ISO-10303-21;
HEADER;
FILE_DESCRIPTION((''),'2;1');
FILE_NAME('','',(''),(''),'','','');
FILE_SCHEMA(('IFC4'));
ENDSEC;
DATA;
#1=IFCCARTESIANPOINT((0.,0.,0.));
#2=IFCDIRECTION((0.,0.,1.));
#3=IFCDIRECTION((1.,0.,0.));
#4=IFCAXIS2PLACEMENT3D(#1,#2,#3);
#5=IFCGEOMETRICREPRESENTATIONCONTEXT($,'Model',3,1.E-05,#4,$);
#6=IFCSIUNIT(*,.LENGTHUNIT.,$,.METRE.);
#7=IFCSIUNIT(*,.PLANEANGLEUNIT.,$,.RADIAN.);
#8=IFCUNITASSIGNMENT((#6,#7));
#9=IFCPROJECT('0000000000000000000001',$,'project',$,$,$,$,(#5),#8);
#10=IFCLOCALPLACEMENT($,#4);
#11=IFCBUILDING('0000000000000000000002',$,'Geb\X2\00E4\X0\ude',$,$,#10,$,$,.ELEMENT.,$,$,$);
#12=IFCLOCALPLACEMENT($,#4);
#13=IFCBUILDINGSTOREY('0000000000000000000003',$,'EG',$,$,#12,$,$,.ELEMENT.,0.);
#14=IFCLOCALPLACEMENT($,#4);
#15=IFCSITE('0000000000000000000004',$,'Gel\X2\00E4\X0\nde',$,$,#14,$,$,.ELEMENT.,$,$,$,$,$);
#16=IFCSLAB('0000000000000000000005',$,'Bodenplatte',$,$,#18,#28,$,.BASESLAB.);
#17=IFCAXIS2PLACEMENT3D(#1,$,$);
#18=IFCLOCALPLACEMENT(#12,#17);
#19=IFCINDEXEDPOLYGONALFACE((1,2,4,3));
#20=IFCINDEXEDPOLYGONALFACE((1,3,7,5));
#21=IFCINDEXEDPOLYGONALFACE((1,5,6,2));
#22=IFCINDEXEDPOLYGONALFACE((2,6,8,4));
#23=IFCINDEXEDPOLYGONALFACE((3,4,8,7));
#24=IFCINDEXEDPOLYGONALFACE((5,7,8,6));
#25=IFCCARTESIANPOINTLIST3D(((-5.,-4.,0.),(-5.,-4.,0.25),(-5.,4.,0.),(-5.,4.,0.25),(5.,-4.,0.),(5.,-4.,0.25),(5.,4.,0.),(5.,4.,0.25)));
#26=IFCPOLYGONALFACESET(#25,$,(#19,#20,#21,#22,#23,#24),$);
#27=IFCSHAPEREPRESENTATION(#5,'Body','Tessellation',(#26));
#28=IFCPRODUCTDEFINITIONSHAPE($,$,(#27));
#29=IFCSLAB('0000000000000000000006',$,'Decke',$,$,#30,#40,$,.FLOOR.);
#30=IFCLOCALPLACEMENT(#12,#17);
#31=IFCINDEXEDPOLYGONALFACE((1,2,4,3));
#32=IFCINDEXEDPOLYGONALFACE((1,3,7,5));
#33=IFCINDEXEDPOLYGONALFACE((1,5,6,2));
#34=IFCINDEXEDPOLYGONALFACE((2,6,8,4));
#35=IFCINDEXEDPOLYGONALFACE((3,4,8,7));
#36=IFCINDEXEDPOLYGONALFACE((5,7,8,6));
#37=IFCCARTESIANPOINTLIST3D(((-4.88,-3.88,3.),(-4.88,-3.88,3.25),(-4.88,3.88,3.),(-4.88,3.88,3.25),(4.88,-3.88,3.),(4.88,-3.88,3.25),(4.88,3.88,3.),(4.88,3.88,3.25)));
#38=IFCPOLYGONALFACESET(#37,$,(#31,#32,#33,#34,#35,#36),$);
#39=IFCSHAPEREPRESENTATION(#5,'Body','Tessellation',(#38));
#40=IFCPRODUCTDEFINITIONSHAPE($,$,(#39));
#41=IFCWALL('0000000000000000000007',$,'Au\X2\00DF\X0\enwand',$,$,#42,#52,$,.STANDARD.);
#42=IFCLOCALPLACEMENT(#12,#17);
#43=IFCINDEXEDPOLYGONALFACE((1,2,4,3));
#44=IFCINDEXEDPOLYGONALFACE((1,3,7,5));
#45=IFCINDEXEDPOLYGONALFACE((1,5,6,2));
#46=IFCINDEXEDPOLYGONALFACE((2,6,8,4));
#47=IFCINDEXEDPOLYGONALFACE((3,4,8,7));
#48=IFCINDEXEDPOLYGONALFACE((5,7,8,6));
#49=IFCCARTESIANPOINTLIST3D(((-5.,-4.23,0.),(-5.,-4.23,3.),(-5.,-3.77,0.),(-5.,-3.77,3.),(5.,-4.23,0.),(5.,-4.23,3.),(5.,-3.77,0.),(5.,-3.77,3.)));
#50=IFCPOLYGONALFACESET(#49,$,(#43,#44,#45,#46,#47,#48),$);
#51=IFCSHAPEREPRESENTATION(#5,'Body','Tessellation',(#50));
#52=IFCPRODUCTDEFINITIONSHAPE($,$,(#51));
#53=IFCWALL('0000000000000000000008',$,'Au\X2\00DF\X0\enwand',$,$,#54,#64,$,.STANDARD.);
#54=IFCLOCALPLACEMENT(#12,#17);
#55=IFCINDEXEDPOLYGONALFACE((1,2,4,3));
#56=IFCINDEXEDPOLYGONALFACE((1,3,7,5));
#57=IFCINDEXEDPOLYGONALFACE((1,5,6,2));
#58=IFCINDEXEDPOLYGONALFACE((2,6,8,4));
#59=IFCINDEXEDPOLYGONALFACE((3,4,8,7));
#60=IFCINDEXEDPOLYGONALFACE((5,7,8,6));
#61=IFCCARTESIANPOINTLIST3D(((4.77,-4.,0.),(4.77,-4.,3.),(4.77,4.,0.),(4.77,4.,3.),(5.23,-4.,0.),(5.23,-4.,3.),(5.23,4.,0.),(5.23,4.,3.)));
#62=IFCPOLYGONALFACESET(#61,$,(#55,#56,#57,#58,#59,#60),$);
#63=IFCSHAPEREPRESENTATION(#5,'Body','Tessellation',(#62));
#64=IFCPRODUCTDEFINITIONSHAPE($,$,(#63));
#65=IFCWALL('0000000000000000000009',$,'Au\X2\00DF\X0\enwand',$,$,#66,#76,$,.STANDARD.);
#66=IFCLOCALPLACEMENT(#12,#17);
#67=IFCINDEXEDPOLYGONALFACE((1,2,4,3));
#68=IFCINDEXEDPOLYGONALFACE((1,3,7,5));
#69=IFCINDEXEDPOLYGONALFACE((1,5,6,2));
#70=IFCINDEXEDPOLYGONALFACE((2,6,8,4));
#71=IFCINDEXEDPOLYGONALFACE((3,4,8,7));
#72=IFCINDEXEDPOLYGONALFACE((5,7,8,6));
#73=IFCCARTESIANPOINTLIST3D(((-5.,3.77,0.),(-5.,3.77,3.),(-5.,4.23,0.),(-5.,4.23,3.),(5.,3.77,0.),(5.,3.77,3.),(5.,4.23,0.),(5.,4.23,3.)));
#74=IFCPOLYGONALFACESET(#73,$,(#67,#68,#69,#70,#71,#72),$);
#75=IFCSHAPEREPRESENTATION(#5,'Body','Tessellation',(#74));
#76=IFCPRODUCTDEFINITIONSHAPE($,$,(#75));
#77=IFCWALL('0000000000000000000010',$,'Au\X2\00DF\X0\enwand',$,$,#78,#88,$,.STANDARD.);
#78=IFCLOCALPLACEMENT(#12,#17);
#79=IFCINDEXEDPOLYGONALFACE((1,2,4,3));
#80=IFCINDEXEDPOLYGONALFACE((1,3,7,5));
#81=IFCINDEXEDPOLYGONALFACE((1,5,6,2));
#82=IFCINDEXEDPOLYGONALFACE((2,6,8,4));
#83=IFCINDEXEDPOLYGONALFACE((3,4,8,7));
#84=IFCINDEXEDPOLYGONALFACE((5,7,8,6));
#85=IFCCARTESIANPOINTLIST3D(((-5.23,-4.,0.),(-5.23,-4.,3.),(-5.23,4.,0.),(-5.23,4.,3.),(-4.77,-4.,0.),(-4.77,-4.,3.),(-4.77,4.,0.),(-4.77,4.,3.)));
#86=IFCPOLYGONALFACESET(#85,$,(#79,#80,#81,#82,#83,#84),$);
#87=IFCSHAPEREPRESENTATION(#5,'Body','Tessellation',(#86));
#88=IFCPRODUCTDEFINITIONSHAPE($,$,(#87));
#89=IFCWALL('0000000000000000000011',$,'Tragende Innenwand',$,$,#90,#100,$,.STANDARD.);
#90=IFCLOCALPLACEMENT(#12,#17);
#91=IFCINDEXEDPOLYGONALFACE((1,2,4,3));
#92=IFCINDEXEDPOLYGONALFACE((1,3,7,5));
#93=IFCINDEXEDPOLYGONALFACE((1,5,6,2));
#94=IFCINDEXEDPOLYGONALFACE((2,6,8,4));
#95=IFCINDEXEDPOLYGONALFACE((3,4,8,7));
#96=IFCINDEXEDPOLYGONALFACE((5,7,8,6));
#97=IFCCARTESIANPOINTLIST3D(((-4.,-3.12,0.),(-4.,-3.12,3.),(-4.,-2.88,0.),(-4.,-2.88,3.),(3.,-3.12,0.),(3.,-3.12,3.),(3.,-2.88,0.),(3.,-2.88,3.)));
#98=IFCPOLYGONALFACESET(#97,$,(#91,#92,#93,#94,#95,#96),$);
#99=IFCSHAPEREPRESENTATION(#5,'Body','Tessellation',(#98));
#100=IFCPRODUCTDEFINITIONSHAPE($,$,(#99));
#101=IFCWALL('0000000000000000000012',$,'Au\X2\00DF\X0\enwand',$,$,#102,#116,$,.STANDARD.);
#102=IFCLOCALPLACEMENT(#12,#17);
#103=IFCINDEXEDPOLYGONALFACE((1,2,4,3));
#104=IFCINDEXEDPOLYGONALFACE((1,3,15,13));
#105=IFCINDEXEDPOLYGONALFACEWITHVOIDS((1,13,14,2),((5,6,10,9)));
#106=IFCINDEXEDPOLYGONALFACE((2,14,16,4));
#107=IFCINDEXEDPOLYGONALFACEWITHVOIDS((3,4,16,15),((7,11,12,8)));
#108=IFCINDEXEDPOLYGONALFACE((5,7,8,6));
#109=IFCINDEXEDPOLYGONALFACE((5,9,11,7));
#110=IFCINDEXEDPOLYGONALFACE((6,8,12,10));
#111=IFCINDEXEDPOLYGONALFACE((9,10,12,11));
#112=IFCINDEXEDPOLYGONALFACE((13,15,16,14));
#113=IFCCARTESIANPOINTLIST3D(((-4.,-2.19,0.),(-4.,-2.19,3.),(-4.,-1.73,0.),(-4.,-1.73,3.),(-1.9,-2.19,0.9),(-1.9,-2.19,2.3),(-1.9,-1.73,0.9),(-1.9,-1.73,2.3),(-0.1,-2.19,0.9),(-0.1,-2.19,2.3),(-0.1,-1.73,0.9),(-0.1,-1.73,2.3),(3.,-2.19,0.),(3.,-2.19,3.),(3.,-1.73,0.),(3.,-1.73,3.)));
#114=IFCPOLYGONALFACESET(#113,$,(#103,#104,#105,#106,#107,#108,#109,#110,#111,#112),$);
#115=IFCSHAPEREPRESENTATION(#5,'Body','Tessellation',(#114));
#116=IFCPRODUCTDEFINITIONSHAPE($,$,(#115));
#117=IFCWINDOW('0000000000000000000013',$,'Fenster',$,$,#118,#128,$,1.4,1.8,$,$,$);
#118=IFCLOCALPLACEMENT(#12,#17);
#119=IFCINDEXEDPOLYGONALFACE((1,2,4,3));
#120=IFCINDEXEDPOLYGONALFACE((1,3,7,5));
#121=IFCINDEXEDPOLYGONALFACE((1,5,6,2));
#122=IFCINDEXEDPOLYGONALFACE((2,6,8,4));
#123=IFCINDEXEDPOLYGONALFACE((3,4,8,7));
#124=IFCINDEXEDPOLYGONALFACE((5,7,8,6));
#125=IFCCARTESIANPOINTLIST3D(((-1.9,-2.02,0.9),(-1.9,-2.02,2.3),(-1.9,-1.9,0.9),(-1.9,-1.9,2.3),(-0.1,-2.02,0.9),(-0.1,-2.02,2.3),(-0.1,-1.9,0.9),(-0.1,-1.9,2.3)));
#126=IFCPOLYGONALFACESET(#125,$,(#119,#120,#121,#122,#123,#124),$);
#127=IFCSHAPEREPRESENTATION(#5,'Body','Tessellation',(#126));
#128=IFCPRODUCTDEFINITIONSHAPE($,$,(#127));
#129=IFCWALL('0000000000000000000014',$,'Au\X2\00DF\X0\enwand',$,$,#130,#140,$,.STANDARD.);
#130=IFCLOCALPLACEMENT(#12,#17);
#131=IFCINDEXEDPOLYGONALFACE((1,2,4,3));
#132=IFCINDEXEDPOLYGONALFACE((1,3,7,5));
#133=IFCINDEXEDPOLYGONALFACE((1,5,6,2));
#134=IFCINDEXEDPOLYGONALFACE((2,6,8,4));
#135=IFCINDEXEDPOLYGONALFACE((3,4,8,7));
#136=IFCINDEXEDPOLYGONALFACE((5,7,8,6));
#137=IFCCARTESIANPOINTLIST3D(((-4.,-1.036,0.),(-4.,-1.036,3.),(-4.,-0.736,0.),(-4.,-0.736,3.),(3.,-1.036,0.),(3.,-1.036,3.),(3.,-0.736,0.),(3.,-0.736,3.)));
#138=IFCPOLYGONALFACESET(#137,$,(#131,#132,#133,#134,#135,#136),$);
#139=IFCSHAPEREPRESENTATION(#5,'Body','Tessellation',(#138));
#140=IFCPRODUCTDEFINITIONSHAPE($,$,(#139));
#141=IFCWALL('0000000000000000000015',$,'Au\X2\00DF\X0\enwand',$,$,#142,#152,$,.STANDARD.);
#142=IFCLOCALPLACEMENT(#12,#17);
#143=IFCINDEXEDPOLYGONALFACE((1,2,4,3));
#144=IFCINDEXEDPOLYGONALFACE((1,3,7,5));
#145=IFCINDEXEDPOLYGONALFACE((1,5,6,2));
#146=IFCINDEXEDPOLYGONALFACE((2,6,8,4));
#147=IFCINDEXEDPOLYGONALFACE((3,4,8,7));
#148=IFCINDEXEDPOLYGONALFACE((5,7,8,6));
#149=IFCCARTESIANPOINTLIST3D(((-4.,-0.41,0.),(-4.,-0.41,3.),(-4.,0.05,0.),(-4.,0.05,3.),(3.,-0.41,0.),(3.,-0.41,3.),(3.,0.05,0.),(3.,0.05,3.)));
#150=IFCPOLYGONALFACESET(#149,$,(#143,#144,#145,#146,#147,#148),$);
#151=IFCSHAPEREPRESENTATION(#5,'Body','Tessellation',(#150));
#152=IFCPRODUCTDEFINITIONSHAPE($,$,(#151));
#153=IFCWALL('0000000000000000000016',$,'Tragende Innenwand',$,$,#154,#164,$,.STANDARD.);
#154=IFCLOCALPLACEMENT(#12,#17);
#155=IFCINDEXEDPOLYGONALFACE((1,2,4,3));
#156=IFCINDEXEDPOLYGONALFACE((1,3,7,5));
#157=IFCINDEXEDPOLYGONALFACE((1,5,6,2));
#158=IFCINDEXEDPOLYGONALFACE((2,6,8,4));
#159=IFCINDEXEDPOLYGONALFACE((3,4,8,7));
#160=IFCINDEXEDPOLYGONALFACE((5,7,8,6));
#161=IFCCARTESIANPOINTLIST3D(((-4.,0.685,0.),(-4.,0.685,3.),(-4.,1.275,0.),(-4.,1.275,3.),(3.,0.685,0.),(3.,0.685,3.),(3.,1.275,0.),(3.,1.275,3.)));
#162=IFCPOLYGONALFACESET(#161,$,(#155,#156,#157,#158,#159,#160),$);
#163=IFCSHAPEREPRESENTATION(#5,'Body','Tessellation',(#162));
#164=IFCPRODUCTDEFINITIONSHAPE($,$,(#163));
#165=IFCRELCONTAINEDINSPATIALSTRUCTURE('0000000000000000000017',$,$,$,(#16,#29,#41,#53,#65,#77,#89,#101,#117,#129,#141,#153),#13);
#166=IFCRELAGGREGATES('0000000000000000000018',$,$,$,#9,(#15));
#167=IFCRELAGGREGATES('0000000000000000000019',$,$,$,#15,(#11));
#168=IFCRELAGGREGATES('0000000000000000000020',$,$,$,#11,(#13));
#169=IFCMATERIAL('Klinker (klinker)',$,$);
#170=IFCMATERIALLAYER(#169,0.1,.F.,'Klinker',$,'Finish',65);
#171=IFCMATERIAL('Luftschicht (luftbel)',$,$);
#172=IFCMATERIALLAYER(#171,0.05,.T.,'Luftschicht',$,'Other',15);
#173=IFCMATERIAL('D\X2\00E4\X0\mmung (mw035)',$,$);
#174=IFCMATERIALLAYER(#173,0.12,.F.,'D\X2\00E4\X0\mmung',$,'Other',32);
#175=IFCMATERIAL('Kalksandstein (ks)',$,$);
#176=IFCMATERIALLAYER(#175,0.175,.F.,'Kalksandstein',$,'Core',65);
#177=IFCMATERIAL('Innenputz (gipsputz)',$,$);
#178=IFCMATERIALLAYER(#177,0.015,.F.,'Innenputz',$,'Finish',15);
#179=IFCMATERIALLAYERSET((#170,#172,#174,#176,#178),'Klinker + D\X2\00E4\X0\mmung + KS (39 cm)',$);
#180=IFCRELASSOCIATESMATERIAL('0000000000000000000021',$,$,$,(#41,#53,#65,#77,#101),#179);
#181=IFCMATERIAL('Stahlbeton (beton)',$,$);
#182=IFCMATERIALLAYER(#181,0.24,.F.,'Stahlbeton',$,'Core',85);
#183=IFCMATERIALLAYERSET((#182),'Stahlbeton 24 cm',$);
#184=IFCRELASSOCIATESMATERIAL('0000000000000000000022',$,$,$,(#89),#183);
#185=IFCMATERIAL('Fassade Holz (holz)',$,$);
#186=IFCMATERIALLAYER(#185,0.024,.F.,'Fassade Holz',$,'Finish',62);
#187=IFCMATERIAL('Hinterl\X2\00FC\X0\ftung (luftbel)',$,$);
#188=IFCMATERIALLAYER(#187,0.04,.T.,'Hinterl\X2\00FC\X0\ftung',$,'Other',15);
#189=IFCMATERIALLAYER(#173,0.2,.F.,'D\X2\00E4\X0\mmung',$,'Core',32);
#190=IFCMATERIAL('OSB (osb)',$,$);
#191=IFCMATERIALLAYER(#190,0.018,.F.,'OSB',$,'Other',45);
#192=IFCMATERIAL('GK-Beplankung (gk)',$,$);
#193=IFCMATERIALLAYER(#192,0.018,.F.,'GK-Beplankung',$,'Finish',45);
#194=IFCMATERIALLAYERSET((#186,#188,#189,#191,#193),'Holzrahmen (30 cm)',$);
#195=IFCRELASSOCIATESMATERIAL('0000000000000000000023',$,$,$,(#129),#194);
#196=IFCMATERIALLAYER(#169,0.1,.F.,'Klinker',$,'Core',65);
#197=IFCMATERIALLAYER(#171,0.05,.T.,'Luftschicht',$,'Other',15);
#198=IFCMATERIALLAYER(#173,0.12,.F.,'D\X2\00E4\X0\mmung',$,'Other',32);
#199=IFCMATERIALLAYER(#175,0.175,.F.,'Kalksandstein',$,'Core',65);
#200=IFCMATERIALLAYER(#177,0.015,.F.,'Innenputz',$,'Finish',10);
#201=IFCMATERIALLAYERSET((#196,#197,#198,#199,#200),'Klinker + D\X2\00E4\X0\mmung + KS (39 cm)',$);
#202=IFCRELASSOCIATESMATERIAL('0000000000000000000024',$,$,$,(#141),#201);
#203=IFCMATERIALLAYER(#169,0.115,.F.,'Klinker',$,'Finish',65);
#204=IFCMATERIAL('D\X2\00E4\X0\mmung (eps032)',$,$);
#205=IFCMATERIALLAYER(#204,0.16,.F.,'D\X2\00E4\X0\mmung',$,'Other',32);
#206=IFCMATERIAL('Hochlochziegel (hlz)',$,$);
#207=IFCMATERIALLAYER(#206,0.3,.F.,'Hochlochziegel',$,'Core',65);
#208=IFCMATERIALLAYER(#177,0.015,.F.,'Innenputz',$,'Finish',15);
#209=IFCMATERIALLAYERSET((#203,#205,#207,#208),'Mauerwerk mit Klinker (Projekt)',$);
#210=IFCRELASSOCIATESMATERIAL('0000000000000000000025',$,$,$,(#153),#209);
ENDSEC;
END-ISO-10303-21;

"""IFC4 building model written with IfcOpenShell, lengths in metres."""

from ifc_helpers import new_model, si_unit, frame, origin_with_axes, origin_2d, place, context, project, spatial, polyline, rectangle, outline, extrude, material, layer, layer_set, layer_usage, element, fill, save


model = new_model("IFC4")

# Units and contexts
model_context = context("Model", 3, precision=1e-05, world=origin_with_axes())
ifc_project = project(units=[si_unit("LENGTHUNIT", "METRE"), si_unit("PLANEANGLEUNIT", "RADIAN")], contexts=[model_context])

# Site, building, storey
site_placement = place(None, origin_with_axes())
site = spatial("IfcSite", under=ifc_project, at=site_placement, Name="Gelände", CompositionType="ELEMENT")
building_placement = place(None, origin_with_axes())
building = spatial("IfcBuilding", under=site, at=building_placement, Name="Gebäude", CompositionType="ELEMENT")
storey_placement = place(None, origin_with_axes())
storey = spatial("IfcBuildingStorey", under=building, at=storey_placement, Name="EG", CompositionType="ELEMENT", Elevation=0.0)

# Slabs
slab_1_placement = place(None, origin_with_axes())
element("IfcSlab", 1, at=slab_1_placement, inside=storey, Name="Bodenplatte", PredefinedType="BASESLAB", context=model_context, shape_type="SweptSolid", body=[
    extrude(outline(polyline([(-5.0, -4.0), (5.0, -4.0), (5.0, 4.0), (-5.0, 4.0), (-5.0, -4.0)])), origin_with_axes(), (0.0, 0.0, 1.0), 0.25),
])
slab_2_placement = place(None, frame((0.0, 0.0, 3.0), z_axis=(0.0, 0.0, 1.0), x_axis=(1.0, 0.0, 0.0)))
element("IfcSlab", 2, at=slab_2_placement, inside=storey, Name="Decke", PredefinedType="FLOOR", context=model_context, shape_type="SweptSolid", body=[
    extrude(outline(polyline([(-4.88, -3.88), (4.88, -3.88), (4.88, 3.88), (-4.88, 3.88), (-4.88, -3.88)])), origin_with_axes(), (0.0, 0.0, 1.0), 0.25),
])

# Walls
ifc_material_1 = material(Name="Klinker (klinker)")
ifc_layer_1 = layer(ifc_material_1, 0.1, ventilated=False, Name="Klinker", Category="Finish", Priority=65)
ifc_material_2 = material(Name="Luftschicht (luftbel)")
ifc_layer_2 = layer(ifc_material_2, 0.05, ventilated=True, Name="Luftschicht", Category="Other", Priority=15)
ifc_material_3 = material(Name="Dämmung (mw035)")
ifc_layer_3 = layer(ifc_material_3, 0.12, ventilated=False, Name="Dämmung", Category="Other", Priority=32)
ifc_material_4 = material(Name="Kalksandstein (ks)")
ifc_layer_4 = layer(ifc_material_4, 0.175, ventilated=False, Name="Kalksandstein", Category="Core", Priority=65)
ifc_material_5 = material(Name="Innenputz (gipsputz)")
ifc_layer_5 = layer(ifc_material_5, 0.015, ventilated=False, Name="Innenputz", Category="Finish", Priority=15)
ifc_layer_set_1 = layer_set([ifc_layer_1, ifc_layer_2, ifc_layer_3, ifc_layer_4, ifc_layer_5], Name="Klinker + Dämmung + KS (39 cm)")
ifc_layer_usage_1 = layer_usage(ifc_layer_set_1, "AXIS2", "NEGATIVE", 0.23)
wall_1_placement = place(None, frame((0.0, -4.0, 0.0), z_axis=(0.0, 0.0, 1.0), x_axis=(1.0, 0.0, 0.0)))
element("IfcWall", 3, at=wall_1_placement, inside=storey, material=ifc_layer_usage_1, Name="Außenwand", PredefinedType="STANDARD", context=model_context, shape_type="SweptSolid", body=[
    extrude(rectangle(XDim=10.0, YDim=0.46, at=origin_2d()), origin_with_axes(), (0.0, 0.0, 1.0), 3.0),
])
ifc_layer_usage_2 = layer_usage(ifc_layer_set_1, "AXIS2", "NEGATIVE", 0.23)
wall_2_placement = place(None, frame((5.0, 0.0, 0.0), z_axis=(0.0, 0.0, 1.0), x_axis=(0.0, 1.0, 0.0)))
element("IfcWall", 4, at=wall_2_placement, inside=storey, material=ifc_layer_usage_2, Name="Außenwand", PredefinedType="STANDARD", context=model_context, shape_type="SweptSolid", body=[
    extrude(rectangle(XDim=8.0, YDim=0.46, at=origin_2d()), origin_with_axes(), (0.0, 0.0, 1.0), 3.0),
])
ifc_layer_usage_3 = layer_usage(ifc_layer_set_1, "AXIS2", "NEGATIVE", 0.23)
wall_3_placement = place(None, frame((0.0, 4.0, 0.0), z_axis=(0.0, 0.0, 1.0), x_axis=(-1.0, 0.0, 0.0)))
element("IfcWall", 5, at=wall_3_placement, inside=storey, material=ifc_layer_usage_3, Name="Außenwand", PredefinedType="STANDARD", context=model_context, shape_type="SweptSolid", body=[
    extrude(rectangle(XDim=10.0, YDim=0.46, at=origin_2d()), origin_with_axes(), (0.0, 0.0, 1.0), 3.0),
])
ifc_layer_usage_4 = layer_usage(ifc_layer_set_1, "AXIS2", "NEGATIVE", 0.23)
wall_4_placement = place(None, frame((-5.0, 0.0, 0.0), z_axis=(0.0, 0.0, 1.0), x_axis=(0.0, -1.0, 0.0)))
element("IfcWall", 6, at=wall_4_placement, inside=storey, material=ifc_layer_usage_4, Name="Außenwand", PredefinedType="STANDARD", context=model_context, shape_type="SweptSolid", body=[
    extrude(rectangle(XDim=8.0, YDim=0.46, at=origin_2d()), origin_with_axes(), (0.0, 0.0, 1.0), 3.0),
])
ifc_material_6 = material(Name="Stahlbeton (beton)")
ifc_layer_6 = layer(ifc_material_6, 0.24, ventilated=False, Name="Stahlbeton", Category="Core", Priority=85)
ifc_layer_set_2 = layer_set([ifc_layer_6], Name="Stahlbeton 24 cm")
ifc_layer_usage_5 = layer_usage(ifc_layer_set_2, "AXIS2", "NEGATIVE", 0.12)
wall_5_placement = place(None, frame((-0.5, -3.0, 0.0), z_axis=(0.0, 0.0, 1.0), x_axis=(1.0, 0.0, 0.0)))
element("IfcWall", 7, at=wall_5_placement, inside=storey, material=ifc_layer_usage_5, Name="Tragende Innenwand", PredefinedType="STANDARD", context=model_context, shape_type="SweptSolid", body=[
    extrude(rectangle(XDim=7.0, YDim=0.24, at=origin_2d()), origin_with_axes(), (0.0, 0.0, 1.0), 3.0),
])

# Wall, opening, window
ifc_layer_usage_6 = layer_usage(ifc_layer_set_1, "AXIS2", "NEGATIVE", 0.23)
wall_6_placement = place(None, frame((-0.5, -1.96, 0.0), z_axis=(0.0, 0.0, 1.0), x_axis=(1.0, 0.0, 0.0)))
wall_6 = element("IfcWall", 8, at=wall_6_placement, inside=storey, material=ifc_layer_usage_6, Name="Außenwand", PredefinedType="STANDARD", context=model_context, shape_type="SweptSolid", body=[
    extrude(rectangle(XDim=7.0, YDim=0.46, at=origin_2d()), origin_with_axes(), (0.0, 0.0, 1.0), 3.0),
])
opening_placement = place(wall_6_placement, frame((-0.5, 0.0, 0.9), z_axis=(0.0, 0.0, 1.0), x_axis=(1.0, 0.0, 0.0)))
opening = element("IfcOpeningElement", 9, at=opening_placement, cuts=wall_6, PredefinedType="OPENING", context=model_context, shape_type="SweptSolid", body=[
    extrude(rectangle(XDim=1.8, YDim=0.5, at=origin_2d()), origin_with_axes(), (0.0, 0.0, 1.0), 1.4),
])
window_placement = place(opening_placement, origin_with_axes())
window = element("IfcWindow", 10, at=window_placement, inside=storey, Name="Fenster", OverallHeight=1.4, OverallWidth=1.8, context=model_context, shape_type="SweptSolid", body=[
    extrude(rectangle(XDim=1.8, YDim=0.12, at=origin_2d()), origin_with_axes(), (0.0, 0.0, 1.0), 1.4),
])
fill(opening, window)

# Walls
ifc_material_7 = material(Name="Fassade Holz (holz)")
ifc_layer_7 = layer(ifc_material_7, 0.024, ventilated=False, Name="Fassade Holz", Category="Finish", Priority=62)
ifc_material_8 = material(Name="Hinterlüftung (luftbel)")
ifc_layer_8 = layer(ifc_material_8, 0.04, ventilated=True, Name="Hinterlüftung", Category="Other", Priority=15)
ifc_layer_9 = layer(ifc_material_3, 0.2, ventilated=False, Name="Dämmung", Category="Core", Priority=32)
ifc_material_9 = material(Name="OSB (osb)")
ifc_layer_10 = layer(ifc_material_9, 0.018, ventilated=False, Name="OSB", Category="Other", Priority=45)
ifc_material_10 = material(Name="GK-Beplankung (gk)")
ifc_layer_11 = layer(ifc_material_10, 0.018, ventilated=False, Name="GK-Beplankung", Category="Finish", Priority=45)
ifc_layer_set_3 = layer_set([ifc_layer_7, ifc_layer_8, ifc_layer_9, ifc_layer_10, ifc_layer_11], Name="Holzrahmen (30 cm)")
ifc_layer_usage_7 = layer_usage(ifc_layer_set_3, "AXIS2", "NEGATIVE", 0.15)
wall_7_placement = place(None, frame((-0.5, -0.886, 0.0), z_axis=(0.0, 0.0, 1.0), x_axis=(1.0, 0.0, 0.0)))
element("IfcWall", 11, at=wall_7_placement, inside=storey, material=ifc_layer_usage_7, Name="Außenwand", PredefinedType="STANDARD", context=model_context, shape_type="SweptSolid", body=[
    extrude(rectangle(XDim=7.0, YDim=0.3, at=origin_2d()), origin_with_axes(), (0.0, 0.0, 1.0), 3.0),
])
ifc_layer_12 = layer(ifc_material_1, 0.1, ventilated=False, Name="Klinker", Category="Core", Priority=65)
ifc_layer_13 = layer(ifc_material_2, 0.05, ventilated=True, Name="Luftschicht", Category="Other", Priority=15)
ifc_layer_14 = layer(ifc_material_3, 0.12, ventilated=False, Name="Dämmung", Category="Other", Priority=32)
ifc_layer_15 = layer(ifc_material_4, 0.175, ventilated=False, Name="Kalksandstein", Category="Core", Priority=65)
ifc_layer_16 = layer(ifc_material_5, 0.015, ventilated=False, Name="Innenputz", Category="Finish", Priority=10)
ifc_layer_set_4 = layer_set([ifc_layer_12, ifc_layer_13, ifc_layer_14, ifc_layer_15, ifc_layer_16], Name="Klinker + Dämmung + KS (39 cm)")
ifc_layer_usage_8 = layer_usage(ifc_layer_set_4, "AXIS2", "NEGATIVE", 0.23)
wall_8_placement = place(None, frame((-0.5, -0.18, 0.0), z_axis=(0.0, 0.0, 1.0), x_axis=(1.0, 0.0, 0.0)))
element("IfcWall", 12, at=wall_8_placement, inside=storey, material=ifc_layer_usage_8, Name="Außenwand", PredefinedType="STANDARD", context=model_context, shape_type="SweptSolid", body=[
    extrude(rectangle(XDim=7.0, YDim=0.46, at=origin_2d()), origin_with_axes(), (0.0, 0.0, 1.0), 3.0),
])
ifc_layer_17 = layer(ifc_material_1, 0.115, ventilated=False, Name="Klinker", Category="Finish", Priority=65)
ifc_material_11 = material(Name="Dämmung (eps032)")
ifc_layer_18 = layer(ifc_material_11, 0.16, ventilated=False, Name="Dämmung", Category="Other", Priority=32)
ifc_material_12 = material(Name="Hochlochziegel (hlz)")
ifc_layer_19 = layer(ifc_material_12, 0.3, ventilated=False, Name="Hochlochziegel", Category="Core", Priority=65)
ifc_layer_20 = layer(ifc_material_5, 0.015, ventilated=False, Name="Innenputz", Category="Finish", Priority=15)
ifc_layer_set_5 = layer_set([ifc_layer_17, ifc_layer_18, ifc_layer_19, ifc_layer_20], Name="Mauerwerk mit Klinker (Projekt)")
ifc_layer_usage_9 = layer_usage(ifc_layer_set_5, "AXIS2", "NEGATIVE", 0.295)
wall_9_placement = place(None, frame((-0.5, 0.98, 0.0), z_axis=(0.0, 0.0, 1.0), x_axis=(1.0, 0.0, 0.0)))
element("IfcWall", 13, at=wall_9_placement, inside=storey, material=ifc_layer_usage_9, Name="Tragende Innenwand", PredefinedType="STANDARD", context=model_context, shape_type="SweptSolid", body=[
    extrude(rectangle(XDim=7.0, YDim=0.59, at=origin_2d()), origin_with_axes(), (0.0, 0.0, 1.0), 3.0),
])

save(model, "model.ifc")
